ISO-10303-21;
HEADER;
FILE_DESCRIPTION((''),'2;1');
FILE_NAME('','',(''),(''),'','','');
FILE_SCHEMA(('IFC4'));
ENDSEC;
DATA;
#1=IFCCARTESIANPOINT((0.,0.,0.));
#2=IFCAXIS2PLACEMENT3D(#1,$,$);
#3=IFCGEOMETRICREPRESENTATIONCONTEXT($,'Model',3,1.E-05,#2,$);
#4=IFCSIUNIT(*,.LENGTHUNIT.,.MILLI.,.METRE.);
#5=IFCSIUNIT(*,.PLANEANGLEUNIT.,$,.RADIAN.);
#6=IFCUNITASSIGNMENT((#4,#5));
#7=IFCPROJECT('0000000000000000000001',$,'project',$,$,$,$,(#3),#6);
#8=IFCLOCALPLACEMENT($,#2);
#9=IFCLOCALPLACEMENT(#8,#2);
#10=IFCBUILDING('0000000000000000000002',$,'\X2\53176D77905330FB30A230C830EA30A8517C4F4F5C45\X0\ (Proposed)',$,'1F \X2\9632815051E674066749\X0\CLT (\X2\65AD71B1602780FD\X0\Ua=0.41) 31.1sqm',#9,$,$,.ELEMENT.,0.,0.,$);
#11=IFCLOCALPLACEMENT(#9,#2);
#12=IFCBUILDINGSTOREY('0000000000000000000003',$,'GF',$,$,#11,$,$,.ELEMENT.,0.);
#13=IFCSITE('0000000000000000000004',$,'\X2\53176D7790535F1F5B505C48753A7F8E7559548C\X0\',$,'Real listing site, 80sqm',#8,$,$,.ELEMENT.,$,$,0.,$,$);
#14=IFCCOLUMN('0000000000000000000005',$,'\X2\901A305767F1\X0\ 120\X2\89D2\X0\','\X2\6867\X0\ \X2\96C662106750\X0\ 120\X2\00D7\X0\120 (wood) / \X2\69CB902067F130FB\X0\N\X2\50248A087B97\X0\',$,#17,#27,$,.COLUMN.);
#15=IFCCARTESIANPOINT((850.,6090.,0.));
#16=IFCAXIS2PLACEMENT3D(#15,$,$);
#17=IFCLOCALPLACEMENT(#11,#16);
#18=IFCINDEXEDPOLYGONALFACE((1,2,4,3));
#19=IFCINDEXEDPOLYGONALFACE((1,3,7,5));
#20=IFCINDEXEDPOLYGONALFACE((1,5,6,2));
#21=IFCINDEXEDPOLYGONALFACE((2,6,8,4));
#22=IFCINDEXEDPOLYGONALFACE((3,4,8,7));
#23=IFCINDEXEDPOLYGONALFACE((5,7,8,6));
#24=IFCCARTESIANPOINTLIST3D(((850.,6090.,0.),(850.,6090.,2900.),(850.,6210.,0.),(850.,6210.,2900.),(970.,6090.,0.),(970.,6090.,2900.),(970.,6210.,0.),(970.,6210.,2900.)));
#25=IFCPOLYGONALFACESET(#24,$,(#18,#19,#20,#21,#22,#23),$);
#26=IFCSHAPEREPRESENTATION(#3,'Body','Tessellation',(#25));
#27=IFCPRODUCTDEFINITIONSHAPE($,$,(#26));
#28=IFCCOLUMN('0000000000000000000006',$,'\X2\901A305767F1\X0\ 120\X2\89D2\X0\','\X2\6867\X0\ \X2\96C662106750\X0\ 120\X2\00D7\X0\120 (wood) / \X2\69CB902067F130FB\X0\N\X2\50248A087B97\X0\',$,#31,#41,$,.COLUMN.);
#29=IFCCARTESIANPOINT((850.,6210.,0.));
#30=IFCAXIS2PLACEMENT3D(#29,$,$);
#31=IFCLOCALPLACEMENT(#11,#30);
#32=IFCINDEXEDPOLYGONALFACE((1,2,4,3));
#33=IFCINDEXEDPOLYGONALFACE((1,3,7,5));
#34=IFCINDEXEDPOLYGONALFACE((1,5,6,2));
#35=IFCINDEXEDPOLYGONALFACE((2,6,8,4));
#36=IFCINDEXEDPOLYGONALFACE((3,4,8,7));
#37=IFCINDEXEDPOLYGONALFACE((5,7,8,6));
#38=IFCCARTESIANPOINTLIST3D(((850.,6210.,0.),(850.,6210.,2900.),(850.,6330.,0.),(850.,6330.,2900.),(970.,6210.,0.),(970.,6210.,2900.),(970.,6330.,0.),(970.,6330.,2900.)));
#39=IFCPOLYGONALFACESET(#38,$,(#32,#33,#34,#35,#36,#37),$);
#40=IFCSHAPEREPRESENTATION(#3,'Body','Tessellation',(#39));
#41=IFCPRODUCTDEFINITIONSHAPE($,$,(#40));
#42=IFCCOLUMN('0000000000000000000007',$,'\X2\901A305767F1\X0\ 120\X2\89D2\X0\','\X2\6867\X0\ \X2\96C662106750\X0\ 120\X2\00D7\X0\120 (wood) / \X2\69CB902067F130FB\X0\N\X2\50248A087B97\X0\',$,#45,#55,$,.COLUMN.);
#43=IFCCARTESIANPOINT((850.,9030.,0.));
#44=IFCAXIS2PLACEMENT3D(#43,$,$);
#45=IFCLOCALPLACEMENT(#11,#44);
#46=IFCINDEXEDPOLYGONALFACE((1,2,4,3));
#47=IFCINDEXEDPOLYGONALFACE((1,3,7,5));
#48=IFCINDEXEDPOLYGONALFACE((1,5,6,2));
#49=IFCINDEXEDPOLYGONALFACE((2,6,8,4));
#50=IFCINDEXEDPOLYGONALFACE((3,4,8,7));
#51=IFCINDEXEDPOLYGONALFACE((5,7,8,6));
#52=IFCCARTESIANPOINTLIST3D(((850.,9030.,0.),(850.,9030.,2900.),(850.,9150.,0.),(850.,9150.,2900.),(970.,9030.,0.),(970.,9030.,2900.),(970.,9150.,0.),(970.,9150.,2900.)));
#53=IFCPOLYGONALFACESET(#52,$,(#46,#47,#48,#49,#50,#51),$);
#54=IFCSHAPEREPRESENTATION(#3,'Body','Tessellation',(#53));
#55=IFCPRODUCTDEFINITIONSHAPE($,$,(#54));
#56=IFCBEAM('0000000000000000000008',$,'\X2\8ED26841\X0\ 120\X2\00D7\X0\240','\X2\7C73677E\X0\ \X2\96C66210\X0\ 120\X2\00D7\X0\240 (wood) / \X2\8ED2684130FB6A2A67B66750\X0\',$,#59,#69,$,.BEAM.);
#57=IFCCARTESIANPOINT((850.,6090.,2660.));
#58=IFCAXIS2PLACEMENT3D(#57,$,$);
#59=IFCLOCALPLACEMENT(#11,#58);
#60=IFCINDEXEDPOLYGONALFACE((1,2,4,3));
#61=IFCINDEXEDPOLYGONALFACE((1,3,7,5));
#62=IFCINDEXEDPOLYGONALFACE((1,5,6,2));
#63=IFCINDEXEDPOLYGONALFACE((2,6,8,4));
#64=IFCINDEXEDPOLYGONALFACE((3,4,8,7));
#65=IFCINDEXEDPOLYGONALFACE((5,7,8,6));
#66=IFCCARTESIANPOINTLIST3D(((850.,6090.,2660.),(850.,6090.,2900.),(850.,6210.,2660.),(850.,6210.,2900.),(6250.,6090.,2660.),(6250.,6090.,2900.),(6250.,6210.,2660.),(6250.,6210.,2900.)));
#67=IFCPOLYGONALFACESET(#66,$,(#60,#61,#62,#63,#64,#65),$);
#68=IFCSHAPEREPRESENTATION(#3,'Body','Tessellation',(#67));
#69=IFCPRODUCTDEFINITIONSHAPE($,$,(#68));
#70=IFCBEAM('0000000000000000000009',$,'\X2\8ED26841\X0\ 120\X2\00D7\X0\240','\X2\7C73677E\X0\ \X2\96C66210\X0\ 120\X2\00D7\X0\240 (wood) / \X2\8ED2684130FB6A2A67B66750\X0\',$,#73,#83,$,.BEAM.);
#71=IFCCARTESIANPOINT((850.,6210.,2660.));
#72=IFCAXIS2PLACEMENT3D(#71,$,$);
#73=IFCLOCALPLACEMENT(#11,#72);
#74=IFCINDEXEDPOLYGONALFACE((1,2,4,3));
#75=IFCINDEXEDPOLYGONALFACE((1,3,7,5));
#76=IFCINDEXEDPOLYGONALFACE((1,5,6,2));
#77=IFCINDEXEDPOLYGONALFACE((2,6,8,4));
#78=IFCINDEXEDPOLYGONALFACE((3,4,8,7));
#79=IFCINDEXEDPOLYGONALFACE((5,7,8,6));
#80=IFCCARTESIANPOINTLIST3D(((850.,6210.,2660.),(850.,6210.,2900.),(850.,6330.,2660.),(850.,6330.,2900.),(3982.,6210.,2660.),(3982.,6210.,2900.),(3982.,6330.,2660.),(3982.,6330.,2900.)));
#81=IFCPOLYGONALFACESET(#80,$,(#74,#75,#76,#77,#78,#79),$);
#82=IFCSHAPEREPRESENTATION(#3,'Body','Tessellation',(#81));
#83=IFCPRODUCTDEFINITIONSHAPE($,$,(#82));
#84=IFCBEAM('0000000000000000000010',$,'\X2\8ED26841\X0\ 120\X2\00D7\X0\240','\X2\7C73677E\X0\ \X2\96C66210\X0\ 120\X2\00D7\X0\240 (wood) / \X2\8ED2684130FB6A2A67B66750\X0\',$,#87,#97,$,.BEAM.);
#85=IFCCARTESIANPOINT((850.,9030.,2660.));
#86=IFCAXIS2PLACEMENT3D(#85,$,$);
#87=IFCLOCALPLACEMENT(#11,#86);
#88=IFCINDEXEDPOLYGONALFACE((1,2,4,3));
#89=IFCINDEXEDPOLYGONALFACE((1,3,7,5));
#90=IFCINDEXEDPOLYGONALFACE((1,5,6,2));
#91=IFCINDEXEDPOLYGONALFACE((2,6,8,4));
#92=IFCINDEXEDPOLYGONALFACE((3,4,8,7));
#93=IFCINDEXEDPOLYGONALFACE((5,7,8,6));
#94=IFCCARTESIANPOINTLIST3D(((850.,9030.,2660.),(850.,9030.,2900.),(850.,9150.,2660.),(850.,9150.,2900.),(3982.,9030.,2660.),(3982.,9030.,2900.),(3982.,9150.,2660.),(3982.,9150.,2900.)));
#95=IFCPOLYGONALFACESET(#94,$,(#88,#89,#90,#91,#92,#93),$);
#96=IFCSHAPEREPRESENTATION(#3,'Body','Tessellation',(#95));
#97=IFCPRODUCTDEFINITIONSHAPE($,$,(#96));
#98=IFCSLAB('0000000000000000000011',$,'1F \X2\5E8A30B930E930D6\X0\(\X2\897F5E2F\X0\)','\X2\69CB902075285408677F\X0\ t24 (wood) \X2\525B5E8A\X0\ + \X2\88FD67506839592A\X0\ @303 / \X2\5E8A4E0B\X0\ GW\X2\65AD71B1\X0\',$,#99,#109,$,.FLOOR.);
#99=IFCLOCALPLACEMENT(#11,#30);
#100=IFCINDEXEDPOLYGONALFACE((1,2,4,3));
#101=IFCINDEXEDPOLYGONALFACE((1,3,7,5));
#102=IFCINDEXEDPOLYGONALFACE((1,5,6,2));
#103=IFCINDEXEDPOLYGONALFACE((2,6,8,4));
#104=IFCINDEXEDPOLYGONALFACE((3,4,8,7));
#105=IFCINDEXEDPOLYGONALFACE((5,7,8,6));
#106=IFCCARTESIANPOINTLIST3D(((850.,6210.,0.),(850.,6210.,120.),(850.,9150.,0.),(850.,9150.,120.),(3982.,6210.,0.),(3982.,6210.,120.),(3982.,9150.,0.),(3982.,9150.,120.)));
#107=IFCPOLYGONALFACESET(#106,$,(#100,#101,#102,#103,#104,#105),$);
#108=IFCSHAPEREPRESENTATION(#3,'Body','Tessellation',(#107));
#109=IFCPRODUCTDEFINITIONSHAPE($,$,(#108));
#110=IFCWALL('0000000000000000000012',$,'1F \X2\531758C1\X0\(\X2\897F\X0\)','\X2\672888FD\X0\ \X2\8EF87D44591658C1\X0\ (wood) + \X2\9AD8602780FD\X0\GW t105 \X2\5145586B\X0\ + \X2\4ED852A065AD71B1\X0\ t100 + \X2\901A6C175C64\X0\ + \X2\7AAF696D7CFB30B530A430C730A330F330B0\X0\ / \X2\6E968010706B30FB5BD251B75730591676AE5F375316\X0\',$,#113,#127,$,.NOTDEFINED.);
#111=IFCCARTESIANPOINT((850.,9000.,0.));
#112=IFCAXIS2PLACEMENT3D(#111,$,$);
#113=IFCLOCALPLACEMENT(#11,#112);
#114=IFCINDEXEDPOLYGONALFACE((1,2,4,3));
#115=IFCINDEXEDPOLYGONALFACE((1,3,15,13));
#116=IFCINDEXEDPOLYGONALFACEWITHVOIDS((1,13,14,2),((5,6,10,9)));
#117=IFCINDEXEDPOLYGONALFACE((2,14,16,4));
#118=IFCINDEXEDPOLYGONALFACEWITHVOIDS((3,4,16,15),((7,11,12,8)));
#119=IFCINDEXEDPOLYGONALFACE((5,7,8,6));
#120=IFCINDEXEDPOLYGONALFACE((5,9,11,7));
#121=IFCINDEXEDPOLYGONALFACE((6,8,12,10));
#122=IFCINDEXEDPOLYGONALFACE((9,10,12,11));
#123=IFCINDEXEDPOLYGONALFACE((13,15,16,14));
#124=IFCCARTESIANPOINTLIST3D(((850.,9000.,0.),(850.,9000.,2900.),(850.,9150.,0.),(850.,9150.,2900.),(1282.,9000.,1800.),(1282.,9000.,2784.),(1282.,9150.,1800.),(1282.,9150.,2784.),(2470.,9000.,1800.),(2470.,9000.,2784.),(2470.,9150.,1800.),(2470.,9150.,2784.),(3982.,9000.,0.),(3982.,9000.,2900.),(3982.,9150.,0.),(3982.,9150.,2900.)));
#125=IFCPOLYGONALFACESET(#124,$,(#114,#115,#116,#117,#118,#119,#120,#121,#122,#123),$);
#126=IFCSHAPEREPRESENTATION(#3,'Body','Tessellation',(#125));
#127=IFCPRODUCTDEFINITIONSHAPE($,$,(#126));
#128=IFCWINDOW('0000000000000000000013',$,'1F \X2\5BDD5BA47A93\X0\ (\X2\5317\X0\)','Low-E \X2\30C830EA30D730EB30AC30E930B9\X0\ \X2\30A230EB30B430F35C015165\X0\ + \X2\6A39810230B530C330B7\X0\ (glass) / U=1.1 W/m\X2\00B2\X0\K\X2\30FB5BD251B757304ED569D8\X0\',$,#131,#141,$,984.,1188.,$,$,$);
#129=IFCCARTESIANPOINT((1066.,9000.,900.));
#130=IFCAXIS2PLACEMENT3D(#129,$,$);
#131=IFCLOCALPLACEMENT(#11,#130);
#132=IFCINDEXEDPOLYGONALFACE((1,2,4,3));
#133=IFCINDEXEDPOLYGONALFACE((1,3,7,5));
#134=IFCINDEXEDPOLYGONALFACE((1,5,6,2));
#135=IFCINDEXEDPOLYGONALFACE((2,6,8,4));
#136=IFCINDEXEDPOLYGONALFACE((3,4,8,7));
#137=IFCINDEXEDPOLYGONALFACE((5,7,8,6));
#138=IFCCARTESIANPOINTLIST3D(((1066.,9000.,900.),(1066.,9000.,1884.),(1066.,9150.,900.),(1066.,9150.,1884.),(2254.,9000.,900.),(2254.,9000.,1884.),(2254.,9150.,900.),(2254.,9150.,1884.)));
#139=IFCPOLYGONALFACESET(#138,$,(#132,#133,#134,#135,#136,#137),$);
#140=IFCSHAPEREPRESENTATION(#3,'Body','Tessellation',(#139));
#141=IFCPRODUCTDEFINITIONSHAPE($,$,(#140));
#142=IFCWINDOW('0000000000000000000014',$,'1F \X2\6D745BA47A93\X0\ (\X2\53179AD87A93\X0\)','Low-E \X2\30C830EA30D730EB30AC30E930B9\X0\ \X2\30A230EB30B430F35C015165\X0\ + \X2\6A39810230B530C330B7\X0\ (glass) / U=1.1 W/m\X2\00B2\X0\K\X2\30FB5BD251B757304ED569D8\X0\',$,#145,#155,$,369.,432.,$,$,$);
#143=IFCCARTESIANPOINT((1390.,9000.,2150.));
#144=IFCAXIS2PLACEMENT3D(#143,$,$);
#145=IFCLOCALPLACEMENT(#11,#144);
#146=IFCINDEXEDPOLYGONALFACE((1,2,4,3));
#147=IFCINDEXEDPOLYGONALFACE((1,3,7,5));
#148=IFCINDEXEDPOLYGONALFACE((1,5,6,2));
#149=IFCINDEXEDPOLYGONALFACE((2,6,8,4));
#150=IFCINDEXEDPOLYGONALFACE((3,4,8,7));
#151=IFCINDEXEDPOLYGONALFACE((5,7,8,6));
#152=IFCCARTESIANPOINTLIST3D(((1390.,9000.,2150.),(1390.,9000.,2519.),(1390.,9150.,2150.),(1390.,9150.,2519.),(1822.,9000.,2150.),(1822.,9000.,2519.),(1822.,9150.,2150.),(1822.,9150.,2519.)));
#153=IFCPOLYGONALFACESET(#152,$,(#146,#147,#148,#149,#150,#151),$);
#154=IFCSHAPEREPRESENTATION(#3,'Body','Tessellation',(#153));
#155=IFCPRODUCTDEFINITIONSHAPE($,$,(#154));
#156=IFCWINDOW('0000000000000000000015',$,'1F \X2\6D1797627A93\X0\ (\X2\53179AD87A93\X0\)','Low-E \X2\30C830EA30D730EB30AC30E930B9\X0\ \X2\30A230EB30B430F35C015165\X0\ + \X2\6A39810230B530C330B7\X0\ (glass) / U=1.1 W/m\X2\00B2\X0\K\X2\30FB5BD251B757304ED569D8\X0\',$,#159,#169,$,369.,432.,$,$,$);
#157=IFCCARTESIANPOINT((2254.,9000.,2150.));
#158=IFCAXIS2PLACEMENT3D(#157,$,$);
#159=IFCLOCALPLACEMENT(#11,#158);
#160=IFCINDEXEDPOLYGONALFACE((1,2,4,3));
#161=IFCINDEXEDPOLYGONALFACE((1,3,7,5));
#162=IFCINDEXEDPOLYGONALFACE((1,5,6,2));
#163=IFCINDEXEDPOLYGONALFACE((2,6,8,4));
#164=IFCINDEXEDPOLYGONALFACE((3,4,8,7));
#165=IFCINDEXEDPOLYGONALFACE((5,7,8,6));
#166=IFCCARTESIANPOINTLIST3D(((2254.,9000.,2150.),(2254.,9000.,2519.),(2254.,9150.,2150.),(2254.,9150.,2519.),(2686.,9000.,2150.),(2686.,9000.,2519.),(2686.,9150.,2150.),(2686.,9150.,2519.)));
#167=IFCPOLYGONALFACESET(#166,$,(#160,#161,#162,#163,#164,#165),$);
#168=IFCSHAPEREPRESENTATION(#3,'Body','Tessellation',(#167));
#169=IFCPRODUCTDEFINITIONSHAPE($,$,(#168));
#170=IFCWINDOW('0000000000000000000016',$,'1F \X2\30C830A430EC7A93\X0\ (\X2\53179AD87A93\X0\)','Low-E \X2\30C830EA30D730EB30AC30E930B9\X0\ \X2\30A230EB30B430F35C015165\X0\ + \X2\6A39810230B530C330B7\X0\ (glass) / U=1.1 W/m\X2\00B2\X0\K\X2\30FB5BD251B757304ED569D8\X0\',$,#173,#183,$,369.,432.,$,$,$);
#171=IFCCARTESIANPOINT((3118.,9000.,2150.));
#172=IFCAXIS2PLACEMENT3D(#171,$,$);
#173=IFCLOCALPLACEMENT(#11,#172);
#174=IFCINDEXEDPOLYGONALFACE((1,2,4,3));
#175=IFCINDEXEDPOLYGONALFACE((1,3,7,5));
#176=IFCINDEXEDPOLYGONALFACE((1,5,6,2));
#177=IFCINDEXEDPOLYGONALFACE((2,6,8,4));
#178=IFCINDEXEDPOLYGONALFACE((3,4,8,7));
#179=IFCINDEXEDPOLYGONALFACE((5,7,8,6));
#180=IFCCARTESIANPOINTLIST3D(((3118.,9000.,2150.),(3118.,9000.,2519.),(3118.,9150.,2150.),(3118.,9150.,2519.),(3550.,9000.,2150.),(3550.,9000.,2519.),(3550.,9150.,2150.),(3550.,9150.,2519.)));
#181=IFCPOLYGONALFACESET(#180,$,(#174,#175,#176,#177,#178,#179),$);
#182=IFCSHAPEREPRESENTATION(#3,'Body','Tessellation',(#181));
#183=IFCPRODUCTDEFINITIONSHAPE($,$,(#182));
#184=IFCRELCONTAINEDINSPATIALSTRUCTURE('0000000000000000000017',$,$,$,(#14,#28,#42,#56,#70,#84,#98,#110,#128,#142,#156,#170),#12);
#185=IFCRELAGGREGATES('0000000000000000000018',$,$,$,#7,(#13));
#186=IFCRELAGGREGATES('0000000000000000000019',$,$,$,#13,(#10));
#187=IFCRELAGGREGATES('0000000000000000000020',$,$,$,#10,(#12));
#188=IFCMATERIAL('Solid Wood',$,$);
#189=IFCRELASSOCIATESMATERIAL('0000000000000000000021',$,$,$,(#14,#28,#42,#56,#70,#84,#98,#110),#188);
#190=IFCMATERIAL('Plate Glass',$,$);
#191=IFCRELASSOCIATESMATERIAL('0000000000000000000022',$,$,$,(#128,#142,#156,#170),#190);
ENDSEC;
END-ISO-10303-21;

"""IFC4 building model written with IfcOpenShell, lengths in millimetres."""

from ifc_helpers import new_model, si_unit, frame, frame_2d, origin, place, context, project, spatial, rectangle, extrude, material, element, fill, save


model = new_model("IFC4")

# Units and contexts
model_context = context("Model", 3, precision=1e-05, world=origin())
ifc_project = project(units=[si_unit("LENGTHUNIT", "METRE", prefix="MILLI"), si_unit("PLANEANGLEUNIT", "RADIAN")], contexts=[model_context])

# Site, building, storey
site_placement = place(None, origin())
site = spatial("IfcSite", under=ifc_project, at=site_placement, Name="北海道弟子屈町美留和", ObjectType="Real listing site, 80sqm", CompositionType="ELEMENT", RefElevation=0.0)
building_placement = place(site_placement, origin())
building = spatial("IfcBuilding", under=site, at=building_placement, Name="北海道・アトリエ兼住居 (Proposed)", ObjectType="1F 防腐処理杉CLT (断熱性能Ua=0.41) 31.1sqm", CompositionType="ELEMENT", ElevationOfRefHeight=0.0, ElevationOfTerrain=0.0)
storey_placement = place(building_placement, origin())
storey = spatial("IfcBuildingStorey", under=building, at=storey_placement, Name="GF", CompositionType="ELEMENT", Elevation=0.0)

# Columns
ifc_material_1 = material(Name="Solid Wood")
column_1_placement = place(storey_placement, frame((850.0, 6090.0, 0.0)))
element("IfcColumn", 1, at=column_1_placement, inside=storey, material=ifc_material_1, Name="通し柱 120角", Description="桧 集成材 120×120 (wood) / 構造柱・N値計算", PredefinedType="COLUMN", context=model_context, shape_type="SweptSolid", body=[
    extrude(rectangle(XDim=120.0, YDim=120.0, at=frame_2d((60.0, 60.0))), frame((850.0, 6090.0, 0.0)), (0.0, 0.0, 1.0), 2900.0),
])
column_2_placement = place(storey_placement, frame((850.0, 6210.0, 0.0)))
element("IfcColumn", 2, at=column_2_placement, inside=storey, material=ifc_material_1, Name="通し柱 120角", Description="桧 集成材 120×120 (wood) / 構造柱・N値計算", PredefinedType="COLUMN", context=model_context, shape_type="SweptSolid", body=[
    extrude(rectangle(XDim=120.0, YDim=120.0, at=frame_2d((60.0, 60.0))), frame((850.0, 6210.0, 0.0)), (0.0, 0.0, 1.0), 2900.0),
])
column_3_placement = place(storey_placement, frame((850.0, 9030.0, 0.0)))
element("IfcColumn", 3, at=column_3_placement, inside=storey, material=ifc_material_1, Name="通し柱 120角", Description="桧 集成材 120×120 (wood) / 構造柱・N値計算", PredefinedType="COLUMN", context=model_context, shape_type="SweptSolid", body=[
    extrude(rectangle(XDim=120.0, YDim=120.0, at=frame_2d((60.0, 60.0))), frame((850.0, 9030.0, 0.0)), (0.0, 0.0, 1.0), 2900.0),
])

# Beams
beam_1_placement = place(storey_placement, frame((850.0, 6090.0, 2660.0)))
element("IfcBeam", 4, at=beam_1_placement, inside=storey, material=ifc_material_1, Name="軒桁 120×240", Description="米松 集成 120×240 (wood) / 軒桁・横架材", PredefinedType="BEAM", context=model_context, shape_type="SweptSolid", body=[
    extrude(rectangle(XDim=5400.0, YDim=120.0, at=frame_2d((2700.0, 60.0))), frame((850.0, 6090.0, 2660.0)), (0.0, 0.0, 1.0), 240.0),
])
beam_2_placement = place(storey_placement, frame((850.0, 6210.0, 2660.0)))
element("IfcBeam", 5, at=beam_2_placement, inside=storey, material=ifc_material_1, Name="軒桁 120×240", Description="米松 集成 120×240 (wood) / 軒桁・横架材", PredefinedType="BEAM", context=model_context, shape_type="SweptSolid", body=[
    extrude(rectangle(XDim=3132.0, YDim=120.0, at=frame_2d((1566.0, 60.0))), frame((850.0, 6210.0, 2660.0)), (0.0, 0.0, 1.0), 240.0),
])
beam_3_placement = place(storey_placement, frame((850.0, 9030.0, 2660.0)))
element("IfcBeam", 6, at=beam_3_placement, inside=storey, material=ifc_material_1, Name="軒桁 120×240", Description="米松 集成 120×240 (wood) / 軒桁・横架材", PredefinedType="BEAM", context=model_context, shape_type="SweptSolid", body=[
    extrude(rectangle(XDim=3132.0, YDim=120.0, at=frame_2d((1566.0, 60.0))), frame((850.0, 9030.0, 2660.0)), (0.0, 0.0, 1.0), 240.0),
])

# Slab
slab_placement = place(storey_placement, frame((850.0, 6210.0, 0.0)))
element("IfcSlab", 7, at=slab_placement, inside=storey, material=ifc_material_1, Name="1F 床スラブ(西帯)", Description="構造用合板 t24 (wood) 剛床 + 製材根太 @303 / 床下 GW断熱", PredefinedType="FLOOR", context=model_context, shape_type="SweptSolid", body=[
    extrude(rectangle(XDim=3132.0, YDim=2940.0, at=frame_2d((1566.0, 1470.0))), frame((850.0, 6210.0, 0.0)), (0.0, 0.0, 1.0), 120.0),
])

# Wall, openings, windows
wall_1_placement = place(storey_placement, frame((850.0, 9000.0, 0.0)))
wall_1 = element("IfcWall", 8, at=wall_1_placement, inside=storey, material=ifc_material_1, Name="1F 北壁(西)", Description="木製 軸組外壁 (wood) + 高性能GW t105 充填 + 付加断熱 t100 + 通気層 + 窯業系サイディング / 準耐火・寒冷地外皮強化", PredefinedType="NOTDEFINED", context=model_context, shape_type="SweptSolid", body=[
    extrude(rectangle(XDim=3132.0, YDim=150.0, at=frame_2d((1566.0, 75.0))), frame((850.0, 9000.0, 0.0)), (0.0, 0.0, 1.0), 2900.0),
])
opening_1_placement = place(storey_placement, frame((1066.0, 9000.0, 900.0)))
opening_1 = element("IfcOpeningElement", 9, at=opening_1_placement, cuts=wall_1, PredefinedType="NOTDEFINED", context=model_context, shape_type="SweptSolid", body=[
    extrude(rectangle(XDim=1188.0, YDim=150.0, at=frame_2d((594.0, 75.0))), frame((1066.0, 9000.0, 900.0)), (0.0, 0.0, 1.0), 984.0),
])
opening_2_placement = place(storey_placement, frame((1390.0, 9000.0, 2150.0)))
opening_2 = element("IfcOpeningElement", 10, at=opening_2_placement, cuts=wall_1, PredefinedType="NOTDEFINED", context=model_context, shape_type="SweptSolid", body=[
    extrude(rectangle(XDim=432.0, YDim=150.0, at=frame_2d((216.0, 75.0))), frame((1390.0, 9000.0, 2150.0)), (0.0, 0.0, 1.0), 369.0),
])
opening_3_placement = place(storey_placement, frame((2254.0, 9000.0, 2150.0)))
opening_3 = element("IfcOpeningElement", 11, at=opening_3_placement, cuts=wall_1, PredefinedType="NOTDEFINED", context=model_context, shape_type="SweptSolid", body=[
    extrude(rectangle(XDim=432.0, YDim=150.0, at=frame_2d((216.0, 75.0))), frame((2254.0, 9000.0, 2150.0)), (0.0, 0.0, 1.0), 369.0),
])
opening_4_placement = place(storey_placement, frame((3118.0, 9000.0, 2150.0)))
opening_4 = element("IfcOpeningElement", 12, at=opening_4_placement, cuts=wall_1, PredefinedType="NOTDEFINED", context=model_context, shape_type="SweptSolid", body=[
    extrude(rectangle(XDim=432.0, YDim=150.0, at=frame_2d((216.0, 75.0))), frame((3118.0, 9000.0, 2150.0)), (0.0, 0.0, 1.0), 369.0),
])
ifc_material_2 = material(Name="Plate Glass")
window_1_placement = place(storey_placement, frame((1066.0, 9000.0, 900.0)))
window_1 = element("IfcWindow", 13, at=window_1_placement, inside=storey, material=ifc_material_2, Name="1F 寝室窓 (北)", Description="Low-E トリプルガラス アルゴン封入 + 樹脂サッシ (glass) / U=1.1 W/m²K・寒冷地仕様", OverallHeight=984.0, OverallWidth=1188.0, context=model_context, shape_type="SweptSolid", body=[
    extrude(rectangle(XDim=1188.0, YDim=150.0, at=frame_2d((594.0, 75.0))), frame((1066.0, 9000.0, 900.0)), (0.0, 0.0, 1.0), 984.0),
])
fill(opening_1, window_1)
window_2_placement = place(storey_placement, frame((1390.0, 9000.0, 2150.0)))
window_2 = element("IfcWindow", 14, at=window_2_placement, inside=storey, material=ifc_material_2, Name="1F 浴室窓 (北高窓)", Description="Low-E トリプルガラス アルゴン封入 + 樹脂サッシ (glass) / U=1.1 W/m²K・寒冷地仕様", OverallHeight=369.0, OverallWidth=432.0, context=model_context, shape_type="SweptSolid", body=[
    extrude(rectangle(XDim=432.0, YDim=150.0, at=frame_2d((216.0, 75.0))), frame((1390.0, 9000.0, 2150.0)), (0.0, 0.0, 1.0), 369.0),
])
fill(opening_2, window_2)
window_3_placement = place(storey_placement, frame((2254.0, 9000.0, 2150.0)))
window_3 = element("IfcWindow", 15, at=window_3_placement, inside=storey, material=ifc_material_2, Name="1F 洗面窓 (北高窓)", Description="Low-E トリプルガラス アルゴン封入 + 樹脂サッシ (glass) / U=1.1 W/m²K・寒冷地仕様", OverallHeight=369.0, OverallWidth=432.0, context=model_context, shape_type="SweptSolid", body=[
    extrude(rectangle(XDim=432.0, YDim=150.0, at=frame_2d((216.0, 75.0))), frame((2254.0, 9000.0, 2150.0)), (0.0, 0.0, 1.0), 369.0),
])
fill(opening_3, window_3)
window_4_placement = place(storey_placement, frame((3118.0, 9000.0, 2150.0)))
window_4 = element("IfcWindow", 16, at=window_4_placement, inside=storey, material=ifc_material_2, Name="1F トイレ窓 (北高窓)", Description="Low-E トリプルガラス アルゴン封入 + 樹脂サッシ (glass) / U=1.1 W/m²K・寒冷地仕様", OverallHeight=369.0, OverallWidth=432.0, context=model_context, shape_type="SweptSolid", body=[
    extrude(rectangle(XDim=432.0, YDim=150.0, at=frame_2d((216.0, 75.0))), frame((3118.0, 9000.0, 2150.0)), (0.0, 0.0, 1.0), 369.0),
])
fill(opening_4, window_4)

save(model, "model.ifc")
